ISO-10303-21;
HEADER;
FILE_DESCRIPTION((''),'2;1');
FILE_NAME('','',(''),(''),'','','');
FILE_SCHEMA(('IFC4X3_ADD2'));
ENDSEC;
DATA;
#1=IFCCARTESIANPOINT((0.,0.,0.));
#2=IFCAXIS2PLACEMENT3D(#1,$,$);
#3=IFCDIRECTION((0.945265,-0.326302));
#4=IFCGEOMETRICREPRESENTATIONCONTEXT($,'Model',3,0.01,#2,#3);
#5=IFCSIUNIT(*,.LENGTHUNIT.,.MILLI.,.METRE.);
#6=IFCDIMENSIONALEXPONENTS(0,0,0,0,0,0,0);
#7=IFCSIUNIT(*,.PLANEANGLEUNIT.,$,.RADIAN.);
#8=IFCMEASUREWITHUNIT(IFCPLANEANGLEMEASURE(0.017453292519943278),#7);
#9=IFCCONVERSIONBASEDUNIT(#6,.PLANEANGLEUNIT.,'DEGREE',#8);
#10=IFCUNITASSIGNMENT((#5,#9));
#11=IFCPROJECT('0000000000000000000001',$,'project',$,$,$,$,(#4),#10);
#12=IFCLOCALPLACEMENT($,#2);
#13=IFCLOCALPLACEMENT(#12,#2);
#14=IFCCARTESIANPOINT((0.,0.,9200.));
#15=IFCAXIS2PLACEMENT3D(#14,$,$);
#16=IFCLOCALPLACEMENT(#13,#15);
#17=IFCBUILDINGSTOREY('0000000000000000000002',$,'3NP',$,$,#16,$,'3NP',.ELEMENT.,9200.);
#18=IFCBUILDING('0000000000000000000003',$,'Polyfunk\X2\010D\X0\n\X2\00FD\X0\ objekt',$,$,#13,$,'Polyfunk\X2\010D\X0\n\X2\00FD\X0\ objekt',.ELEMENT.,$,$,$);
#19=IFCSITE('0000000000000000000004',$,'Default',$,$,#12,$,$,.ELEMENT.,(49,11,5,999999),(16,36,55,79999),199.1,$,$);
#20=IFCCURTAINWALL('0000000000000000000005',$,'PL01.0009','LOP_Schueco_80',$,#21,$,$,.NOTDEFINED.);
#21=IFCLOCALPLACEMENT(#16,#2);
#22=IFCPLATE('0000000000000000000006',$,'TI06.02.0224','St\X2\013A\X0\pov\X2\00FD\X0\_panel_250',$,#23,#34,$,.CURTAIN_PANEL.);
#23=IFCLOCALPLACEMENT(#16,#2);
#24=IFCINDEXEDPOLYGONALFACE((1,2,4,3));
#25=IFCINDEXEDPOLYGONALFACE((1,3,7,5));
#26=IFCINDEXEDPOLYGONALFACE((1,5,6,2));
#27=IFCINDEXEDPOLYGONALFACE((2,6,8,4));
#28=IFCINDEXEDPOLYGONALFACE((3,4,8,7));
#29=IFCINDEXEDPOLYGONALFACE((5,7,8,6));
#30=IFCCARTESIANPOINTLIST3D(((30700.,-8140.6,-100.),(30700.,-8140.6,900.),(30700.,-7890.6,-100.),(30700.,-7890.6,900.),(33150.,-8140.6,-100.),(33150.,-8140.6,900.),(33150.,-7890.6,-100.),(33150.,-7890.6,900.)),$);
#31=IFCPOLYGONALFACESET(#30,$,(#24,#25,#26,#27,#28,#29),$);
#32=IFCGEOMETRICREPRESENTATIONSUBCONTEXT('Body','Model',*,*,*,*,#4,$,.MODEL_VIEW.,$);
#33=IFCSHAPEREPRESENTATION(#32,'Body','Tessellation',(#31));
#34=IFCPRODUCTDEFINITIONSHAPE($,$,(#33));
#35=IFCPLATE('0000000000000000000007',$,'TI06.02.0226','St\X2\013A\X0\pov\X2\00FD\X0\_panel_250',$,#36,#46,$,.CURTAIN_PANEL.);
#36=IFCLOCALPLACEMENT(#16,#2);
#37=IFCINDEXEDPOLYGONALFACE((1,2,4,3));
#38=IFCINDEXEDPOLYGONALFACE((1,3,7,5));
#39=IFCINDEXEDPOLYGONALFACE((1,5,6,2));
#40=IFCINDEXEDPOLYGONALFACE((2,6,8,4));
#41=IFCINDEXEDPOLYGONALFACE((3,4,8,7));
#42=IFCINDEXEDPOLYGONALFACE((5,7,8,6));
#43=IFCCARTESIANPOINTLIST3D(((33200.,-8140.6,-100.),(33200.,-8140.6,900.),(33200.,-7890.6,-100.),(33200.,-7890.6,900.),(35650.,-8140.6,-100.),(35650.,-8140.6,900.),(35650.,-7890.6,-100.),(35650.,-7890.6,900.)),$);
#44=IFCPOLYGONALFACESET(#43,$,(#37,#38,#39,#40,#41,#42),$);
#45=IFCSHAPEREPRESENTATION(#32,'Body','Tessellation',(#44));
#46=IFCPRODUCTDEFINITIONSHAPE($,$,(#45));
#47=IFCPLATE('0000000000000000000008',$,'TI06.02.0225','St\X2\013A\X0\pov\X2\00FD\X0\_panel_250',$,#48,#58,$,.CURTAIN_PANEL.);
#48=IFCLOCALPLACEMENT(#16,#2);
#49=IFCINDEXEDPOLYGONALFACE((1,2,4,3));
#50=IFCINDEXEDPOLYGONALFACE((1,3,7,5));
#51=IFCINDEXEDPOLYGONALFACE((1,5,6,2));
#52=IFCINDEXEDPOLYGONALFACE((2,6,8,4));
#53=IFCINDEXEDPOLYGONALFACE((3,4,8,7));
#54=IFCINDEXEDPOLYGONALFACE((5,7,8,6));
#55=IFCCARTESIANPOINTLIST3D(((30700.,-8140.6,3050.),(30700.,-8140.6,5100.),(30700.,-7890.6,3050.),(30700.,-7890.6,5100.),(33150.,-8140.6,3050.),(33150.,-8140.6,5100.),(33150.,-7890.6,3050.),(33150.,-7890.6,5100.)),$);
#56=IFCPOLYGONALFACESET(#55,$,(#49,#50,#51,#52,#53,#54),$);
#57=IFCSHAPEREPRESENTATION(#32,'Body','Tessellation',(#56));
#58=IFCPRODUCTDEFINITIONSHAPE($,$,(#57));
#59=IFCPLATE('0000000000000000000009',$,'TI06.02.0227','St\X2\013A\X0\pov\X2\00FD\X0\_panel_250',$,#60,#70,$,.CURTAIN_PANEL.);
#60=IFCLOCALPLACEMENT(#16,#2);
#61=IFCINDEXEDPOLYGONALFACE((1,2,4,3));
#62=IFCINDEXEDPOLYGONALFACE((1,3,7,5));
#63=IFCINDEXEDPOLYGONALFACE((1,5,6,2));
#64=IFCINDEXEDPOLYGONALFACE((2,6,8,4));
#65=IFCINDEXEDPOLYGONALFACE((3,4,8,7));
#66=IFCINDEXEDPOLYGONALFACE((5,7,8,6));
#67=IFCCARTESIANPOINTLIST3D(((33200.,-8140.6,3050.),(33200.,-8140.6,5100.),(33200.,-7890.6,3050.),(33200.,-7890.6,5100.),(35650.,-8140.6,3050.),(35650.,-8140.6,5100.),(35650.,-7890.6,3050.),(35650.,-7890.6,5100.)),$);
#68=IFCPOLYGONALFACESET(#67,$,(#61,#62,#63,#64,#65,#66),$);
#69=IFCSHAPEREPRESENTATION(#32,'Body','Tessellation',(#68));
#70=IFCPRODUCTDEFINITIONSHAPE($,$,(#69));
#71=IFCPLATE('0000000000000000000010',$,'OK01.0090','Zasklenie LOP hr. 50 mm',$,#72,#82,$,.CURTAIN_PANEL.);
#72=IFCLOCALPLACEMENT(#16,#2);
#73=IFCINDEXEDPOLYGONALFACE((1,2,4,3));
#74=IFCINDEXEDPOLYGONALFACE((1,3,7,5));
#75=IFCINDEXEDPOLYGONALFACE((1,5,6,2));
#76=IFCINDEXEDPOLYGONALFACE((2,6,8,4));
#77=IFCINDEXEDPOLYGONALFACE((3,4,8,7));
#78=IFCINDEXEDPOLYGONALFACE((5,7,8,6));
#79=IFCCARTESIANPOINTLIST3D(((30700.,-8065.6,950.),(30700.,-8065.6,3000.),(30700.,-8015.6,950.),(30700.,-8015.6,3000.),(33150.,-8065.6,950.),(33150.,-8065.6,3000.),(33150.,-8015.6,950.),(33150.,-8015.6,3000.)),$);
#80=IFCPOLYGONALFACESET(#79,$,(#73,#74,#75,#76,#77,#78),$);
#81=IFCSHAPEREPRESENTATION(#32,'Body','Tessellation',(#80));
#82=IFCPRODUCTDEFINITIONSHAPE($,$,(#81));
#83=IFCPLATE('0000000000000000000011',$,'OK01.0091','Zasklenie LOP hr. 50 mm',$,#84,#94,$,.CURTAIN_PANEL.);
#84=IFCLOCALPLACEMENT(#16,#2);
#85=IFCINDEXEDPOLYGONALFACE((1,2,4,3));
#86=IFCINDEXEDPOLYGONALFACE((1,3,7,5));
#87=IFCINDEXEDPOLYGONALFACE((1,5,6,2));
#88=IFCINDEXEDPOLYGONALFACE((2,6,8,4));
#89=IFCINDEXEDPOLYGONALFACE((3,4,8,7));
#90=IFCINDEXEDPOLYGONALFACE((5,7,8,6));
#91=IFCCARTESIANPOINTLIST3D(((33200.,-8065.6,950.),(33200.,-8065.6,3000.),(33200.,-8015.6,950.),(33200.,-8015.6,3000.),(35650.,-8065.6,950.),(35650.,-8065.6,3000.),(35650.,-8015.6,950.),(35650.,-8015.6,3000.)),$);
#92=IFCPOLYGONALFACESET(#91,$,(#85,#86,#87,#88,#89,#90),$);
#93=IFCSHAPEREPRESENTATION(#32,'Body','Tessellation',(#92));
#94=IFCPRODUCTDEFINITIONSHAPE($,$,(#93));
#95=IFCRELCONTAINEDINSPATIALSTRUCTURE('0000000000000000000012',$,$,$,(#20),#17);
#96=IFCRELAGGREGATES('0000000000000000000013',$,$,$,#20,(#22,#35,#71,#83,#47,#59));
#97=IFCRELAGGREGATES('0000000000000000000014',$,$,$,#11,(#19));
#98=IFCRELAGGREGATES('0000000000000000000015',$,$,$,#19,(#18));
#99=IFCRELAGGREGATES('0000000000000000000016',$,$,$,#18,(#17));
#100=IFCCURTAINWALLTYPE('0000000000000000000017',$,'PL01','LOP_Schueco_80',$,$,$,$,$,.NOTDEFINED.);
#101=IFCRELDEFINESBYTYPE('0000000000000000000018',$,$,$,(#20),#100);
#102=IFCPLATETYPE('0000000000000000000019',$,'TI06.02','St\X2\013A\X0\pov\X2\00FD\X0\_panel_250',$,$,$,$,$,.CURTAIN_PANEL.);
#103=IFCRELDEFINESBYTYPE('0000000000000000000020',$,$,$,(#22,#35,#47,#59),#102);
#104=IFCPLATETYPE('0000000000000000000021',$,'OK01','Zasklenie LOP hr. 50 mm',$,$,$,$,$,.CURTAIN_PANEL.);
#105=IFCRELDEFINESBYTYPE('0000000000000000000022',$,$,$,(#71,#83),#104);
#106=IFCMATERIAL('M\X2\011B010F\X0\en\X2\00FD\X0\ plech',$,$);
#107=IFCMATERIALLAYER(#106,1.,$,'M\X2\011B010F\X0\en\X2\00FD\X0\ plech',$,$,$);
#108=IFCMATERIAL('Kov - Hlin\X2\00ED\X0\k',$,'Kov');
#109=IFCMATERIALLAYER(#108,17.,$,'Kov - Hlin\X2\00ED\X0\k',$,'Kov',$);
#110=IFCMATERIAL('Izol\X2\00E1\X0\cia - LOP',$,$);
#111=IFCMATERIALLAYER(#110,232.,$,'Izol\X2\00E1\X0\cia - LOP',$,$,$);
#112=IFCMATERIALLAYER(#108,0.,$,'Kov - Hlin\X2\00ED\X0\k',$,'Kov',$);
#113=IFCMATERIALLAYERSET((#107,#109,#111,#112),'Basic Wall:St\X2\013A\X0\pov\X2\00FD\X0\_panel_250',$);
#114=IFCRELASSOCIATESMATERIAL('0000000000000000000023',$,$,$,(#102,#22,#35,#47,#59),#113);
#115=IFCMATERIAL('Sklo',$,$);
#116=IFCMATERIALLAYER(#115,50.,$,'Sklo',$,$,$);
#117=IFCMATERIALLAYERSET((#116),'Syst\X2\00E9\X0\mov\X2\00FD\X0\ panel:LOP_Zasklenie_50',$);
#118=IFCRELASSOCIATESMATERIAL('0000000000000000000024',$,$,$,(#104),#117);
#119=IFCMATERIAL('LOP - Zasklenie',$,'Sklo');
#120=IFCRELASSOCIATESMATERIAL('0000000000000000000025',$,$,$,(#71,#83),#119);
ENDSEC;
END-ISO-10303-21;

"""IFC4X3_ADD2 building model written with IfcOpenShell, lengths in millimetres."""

from ifc_helpers import new_model, entity, si_unit, converted_unit, direction, frame, frame_2d, origin, origin_2d_with_axis, place, context, subcontext, project, spatial, rectangle, extrude, source, transform, mapped, material, layer, layer_set, layer_usage, type_object, type_shapes, element, aggregate, save


model = new_model("IFC4X3_ADD2")

# Units and contexts
model_context = context("Model", 3, precision=0.01, world=origin(), true_north=direction((0.945265, -0.326302)))
body_context = subcontext(model_context, "Body", "Model", "MODEL_VIEW")
ifc_project = project(units=[si_unit("LENGTHUNIT", "METRE", prefix="MILLI"), converted_unit("PLANEANGLEUNIT", "DEGREE", entity("IfcPlaneAngleMeasure", 0.017453292519943278), si_unit("PLANEANGLEUNIT", "RADIAN"), dimensions=[0, 0, 0, 0, 0, 0, 0])], contexts=[model_context])

# Site, building, storey
site_placement = place(None, origin())
site = spatial("IfcSite", under=ifc_project, at=site_placement, Name="Default", CompositionType="ELEMENT", RefLatitude=(49, 11, 5, 999999), RefLongitude=(16, 36, 55, 79999), RefElevation=199.1)
building_placement = place(site_placement, origin())
building = spatial("IfcBuilding", under=site, at=building_placement, Name="Polyfunkčný objekt", LongName="Polyfunkčný objekt", CompositionType="ELEMENT")
storey_placement = place(building_placement, frame((0.0, 0.0, 9200.0)))
storey = spatial("IfcBuildingStorey", under=building, at=storey_placement, Name="3NP", LongName="3NP", CompositionType="ELEMENT", Elevation=9200.0)

# Curtain wall, plates
curtain_wall_type = type_object("IfcCurtainWallType", Name="PL01", Description="LOP_Schueco_80", PredefinedType="NOTDEFINED")
curtain_wall_placement = place(storey_placement, frame((0.0, 0.0, -9200.0)))
curtain_wall = element("IfcCurtainWall", 1, at=curtain_wall_placement, inside=storey, type_object=curtain_wall_type, Name="PL01.0009", Description="LOP_Schueco_80", PredefinedType="NOTDEFINED")
ifc_material_1 = material(Name="Měďený plech")
ifc_layer_1 = layer(ifc_material_1, 1.0, Name="Měďený plech")
ifc_material_2 = material(Name="Kov - Hliník", Category="Kov")
ifc_layer_2 = layer(ifc_material_2, 17.0, Name="Kov - Hliník", Category="Kov")
ifc_material_3 = material(Name="Izolácia - LOP")
ifc_layer_3 = layer(ifc_material_3, 232.0, Name="Izolácia - LOP")
ifc_layer_4 = layer(ifc_material_2, 0.0, Name="Kov - Hliník", Category="Kov")
ifc_layer_set_1 = layer_set([ifc_layer_1, ifc_layer_2, ifc_layer_3, ifc_layer_4], Name="Basic Wall:Stĺpový_panel_250")
ifc_layer_usage_1 = layer_usage(ifc_layer_set_1, "AXIS2", "POSITIVE", -125.0)
plate_type_1 = type_object("IfcPlateType", Name="TI06.02", Description="Stĺpový_panel_250", PredefinedType="CURTAIN_PANEL", material=ifc_layer_set_1)
plate_1_placement = place(storey_placement, frame((30700.0, -8015.6, -100.0)))
plate_1 = element("IfcPlate", 2, at=plate_1_placement, type_object=plate_type_1, material=ifc_layer_usage_1, Name="TI06.02.0224", Description="Stĺpový_panel_250", PredefinedType="CURTAIN_PANEL", context=body_context, shape_type="SweptSolid", body=[
    extrude(rectangle(XDim=250.0, YDim=2450.0, at=frame_2d((0.0, 0.0), x_axis=(1.0, 0.0))), frame((1225.0, 0.0, 0.0), z_axis=(0.0, 0.0, 1.0), x_axis=(0.0, 1.0, 0.0)), (0.0, 0.0, 1.0), 1000.0),
])
ifc_layer_usage_2 = layer_usage(ifc_layer_set_1, "AXIS2", "POSITIVE", -125.0)
plate_2_placement = place(storey_placement, frame((33200.0, -8015.6, -100.0)))
plate_2 = element("IfcPlate", 3, at=plate_2_placement, type_object=plate_type_1, material=ifc_layer_usage_2, Name="TI06.02.0226", Description="Stĺpový_panel_250", PredefinedType="CURTAIN_PANEL", context=body_context, shape_type="SweptSolid", body=[
    extrude(rectangle(XDim=250.0, YDim=2450.0, at=frame_2d((0.0, 0.0), x_axis=(1.0, 0.0))), frame((1225.0, 0.0, 0.0), z_axis=(0.0, 0.0, 1.0), x_axis=(0.0, 1.0, 0.0)), (0.0, 0.0, 1.0), 1000.0),
])
ifc_layer_usage_3 = layer_usage(ifc_layer_set_1, "AXIS2", "POSITIVE", -125.0)
plate_3_placement = place(storey_placement, frame((30700.0, -8015.6, 3050.0)))
plate_3 = element("IfcPlate", 4, at=plate_3_placement, type_object=plate_type_1, material=ifc_layer_usage_3, Name="TI06.02.0225", Description="Stĺpový_panel_250", PredefinedType="CURTAIN_PANEL", context=body_context, shape_type="SweptSolid", body=[
    extrude(rectangle(XDim=250.0, YDim=2450.0, at=frame_2d((0.0, 0.0), x_axis=(1.0, 0.0))), frame((1225.0, 0.0, 0.0), z_axis=(0.0, 0.0, 1.0), x_axis=(0.0, 1.0, 0.0)), (0.0, 0.0, 1.0), 2050.0),
])
ifc_layer_usage_4 = layer_usage(ifc_layer_set_1, "AXIS2", "POSITIVE", -125.0)
plate_4_placement = place(storey_placement, frame((33200.0, -8015.6, 3050.0)))
plate_4 = element("IfcPlate", 5, at=plate_4_placement, type_object=plate_type_1, material=ifc_layer_usage_4, Name="TI06.02.0227", Description="Stĺpový_panel_250", PredefinedType="CURTAIN_PANEL", context=body_context, shape_type="SweptSolid", body=[
    extrude(rectangle(XDim=250.0, YDim=2450.0, at=frame_2d((0.0, 0.0), x_axis=(1.0, 0.0))), frame((1225.0, 0.0, 0.0), z_axis=(0.0, 0.0, 1.0), x_axis=(0.0, 1.0, 0.0)), (0.0, 0.0, 1.0), 2050.0),
])
ifc_material_4 = material(Name="LOP - Zasklenie", Category="Sklo")
ifc_material_5 = material(Name="Sklo")
ifc_layer_5 = layer(ifc_material_5, 50.0, Name="Sklo")
ifc_layer_set_2 = layer_set([ifc_layer_5], Name="Systémový panel:LOP_Zasklenie_50")
plate_type_2 = type_object("IfcPlateType", Name="OK01", Description="Zasklenie LOP hr. 50 mm", PredefinedType="CURTAIN_PANEL", material=ifc_layer_set_2)
shared_shape_1 = source(origin(), body_context, "Body", "SweptSolid", [
    extrude(rectangle(XDim=50.0, YDim=2450.0, at=origin_2d_with_axis()), frame((0.0, -25.0, 0.0), z_axis=(0.0, 0.0, 1.0), x_axis=(0.0, 1.0, 0.0)), (0.0, 0.0, 1.0), 2050.0),
])
type_shapes(plate_type_2, [shared_shape_1])
plate_5_placement = place(curtain_wall_placement, frame((31925.0, -8015.6, 10150.0)))
plate_5 = element("IfcPlate", 6, at=plate_5_placement, type_object=plate_type_2, material=ifc_material_4, Name="OK01.0090", Description="Zasklenie LOP hr. 50 mm", PredefinedType="CURTAIN_PANEL", context=body_context, shape_type="MappedRepresentation", body=[
    mapped(shared_shape_1, transform((0.0, 0.0, 0.0), scale=1.0)),
])
plate_6_placement = place(curtain_wall_placement, frame((34425.0, -8015.6, 10150.0)))
plate_6 = element("IfcPlate", 7, at=plate_6_placement, type_object=plate_type_2, material=ifc_material_4, Name="OK01.0091", Description="Zasklenie LOP hr. 50 mm", PredefinedType="CURTAIN_PANEL", context=body_context, shape_type="MappedRepresentation", body=[
    mapped(shared_shape_1, transform((0.0, 0.0, 0.0), scale=1.0)),
])
aggregate(curtain_wall, [plate_1, plate_2, plate_5, plate_6, plate_3, plate_4])

save(model, "model.ifc")
